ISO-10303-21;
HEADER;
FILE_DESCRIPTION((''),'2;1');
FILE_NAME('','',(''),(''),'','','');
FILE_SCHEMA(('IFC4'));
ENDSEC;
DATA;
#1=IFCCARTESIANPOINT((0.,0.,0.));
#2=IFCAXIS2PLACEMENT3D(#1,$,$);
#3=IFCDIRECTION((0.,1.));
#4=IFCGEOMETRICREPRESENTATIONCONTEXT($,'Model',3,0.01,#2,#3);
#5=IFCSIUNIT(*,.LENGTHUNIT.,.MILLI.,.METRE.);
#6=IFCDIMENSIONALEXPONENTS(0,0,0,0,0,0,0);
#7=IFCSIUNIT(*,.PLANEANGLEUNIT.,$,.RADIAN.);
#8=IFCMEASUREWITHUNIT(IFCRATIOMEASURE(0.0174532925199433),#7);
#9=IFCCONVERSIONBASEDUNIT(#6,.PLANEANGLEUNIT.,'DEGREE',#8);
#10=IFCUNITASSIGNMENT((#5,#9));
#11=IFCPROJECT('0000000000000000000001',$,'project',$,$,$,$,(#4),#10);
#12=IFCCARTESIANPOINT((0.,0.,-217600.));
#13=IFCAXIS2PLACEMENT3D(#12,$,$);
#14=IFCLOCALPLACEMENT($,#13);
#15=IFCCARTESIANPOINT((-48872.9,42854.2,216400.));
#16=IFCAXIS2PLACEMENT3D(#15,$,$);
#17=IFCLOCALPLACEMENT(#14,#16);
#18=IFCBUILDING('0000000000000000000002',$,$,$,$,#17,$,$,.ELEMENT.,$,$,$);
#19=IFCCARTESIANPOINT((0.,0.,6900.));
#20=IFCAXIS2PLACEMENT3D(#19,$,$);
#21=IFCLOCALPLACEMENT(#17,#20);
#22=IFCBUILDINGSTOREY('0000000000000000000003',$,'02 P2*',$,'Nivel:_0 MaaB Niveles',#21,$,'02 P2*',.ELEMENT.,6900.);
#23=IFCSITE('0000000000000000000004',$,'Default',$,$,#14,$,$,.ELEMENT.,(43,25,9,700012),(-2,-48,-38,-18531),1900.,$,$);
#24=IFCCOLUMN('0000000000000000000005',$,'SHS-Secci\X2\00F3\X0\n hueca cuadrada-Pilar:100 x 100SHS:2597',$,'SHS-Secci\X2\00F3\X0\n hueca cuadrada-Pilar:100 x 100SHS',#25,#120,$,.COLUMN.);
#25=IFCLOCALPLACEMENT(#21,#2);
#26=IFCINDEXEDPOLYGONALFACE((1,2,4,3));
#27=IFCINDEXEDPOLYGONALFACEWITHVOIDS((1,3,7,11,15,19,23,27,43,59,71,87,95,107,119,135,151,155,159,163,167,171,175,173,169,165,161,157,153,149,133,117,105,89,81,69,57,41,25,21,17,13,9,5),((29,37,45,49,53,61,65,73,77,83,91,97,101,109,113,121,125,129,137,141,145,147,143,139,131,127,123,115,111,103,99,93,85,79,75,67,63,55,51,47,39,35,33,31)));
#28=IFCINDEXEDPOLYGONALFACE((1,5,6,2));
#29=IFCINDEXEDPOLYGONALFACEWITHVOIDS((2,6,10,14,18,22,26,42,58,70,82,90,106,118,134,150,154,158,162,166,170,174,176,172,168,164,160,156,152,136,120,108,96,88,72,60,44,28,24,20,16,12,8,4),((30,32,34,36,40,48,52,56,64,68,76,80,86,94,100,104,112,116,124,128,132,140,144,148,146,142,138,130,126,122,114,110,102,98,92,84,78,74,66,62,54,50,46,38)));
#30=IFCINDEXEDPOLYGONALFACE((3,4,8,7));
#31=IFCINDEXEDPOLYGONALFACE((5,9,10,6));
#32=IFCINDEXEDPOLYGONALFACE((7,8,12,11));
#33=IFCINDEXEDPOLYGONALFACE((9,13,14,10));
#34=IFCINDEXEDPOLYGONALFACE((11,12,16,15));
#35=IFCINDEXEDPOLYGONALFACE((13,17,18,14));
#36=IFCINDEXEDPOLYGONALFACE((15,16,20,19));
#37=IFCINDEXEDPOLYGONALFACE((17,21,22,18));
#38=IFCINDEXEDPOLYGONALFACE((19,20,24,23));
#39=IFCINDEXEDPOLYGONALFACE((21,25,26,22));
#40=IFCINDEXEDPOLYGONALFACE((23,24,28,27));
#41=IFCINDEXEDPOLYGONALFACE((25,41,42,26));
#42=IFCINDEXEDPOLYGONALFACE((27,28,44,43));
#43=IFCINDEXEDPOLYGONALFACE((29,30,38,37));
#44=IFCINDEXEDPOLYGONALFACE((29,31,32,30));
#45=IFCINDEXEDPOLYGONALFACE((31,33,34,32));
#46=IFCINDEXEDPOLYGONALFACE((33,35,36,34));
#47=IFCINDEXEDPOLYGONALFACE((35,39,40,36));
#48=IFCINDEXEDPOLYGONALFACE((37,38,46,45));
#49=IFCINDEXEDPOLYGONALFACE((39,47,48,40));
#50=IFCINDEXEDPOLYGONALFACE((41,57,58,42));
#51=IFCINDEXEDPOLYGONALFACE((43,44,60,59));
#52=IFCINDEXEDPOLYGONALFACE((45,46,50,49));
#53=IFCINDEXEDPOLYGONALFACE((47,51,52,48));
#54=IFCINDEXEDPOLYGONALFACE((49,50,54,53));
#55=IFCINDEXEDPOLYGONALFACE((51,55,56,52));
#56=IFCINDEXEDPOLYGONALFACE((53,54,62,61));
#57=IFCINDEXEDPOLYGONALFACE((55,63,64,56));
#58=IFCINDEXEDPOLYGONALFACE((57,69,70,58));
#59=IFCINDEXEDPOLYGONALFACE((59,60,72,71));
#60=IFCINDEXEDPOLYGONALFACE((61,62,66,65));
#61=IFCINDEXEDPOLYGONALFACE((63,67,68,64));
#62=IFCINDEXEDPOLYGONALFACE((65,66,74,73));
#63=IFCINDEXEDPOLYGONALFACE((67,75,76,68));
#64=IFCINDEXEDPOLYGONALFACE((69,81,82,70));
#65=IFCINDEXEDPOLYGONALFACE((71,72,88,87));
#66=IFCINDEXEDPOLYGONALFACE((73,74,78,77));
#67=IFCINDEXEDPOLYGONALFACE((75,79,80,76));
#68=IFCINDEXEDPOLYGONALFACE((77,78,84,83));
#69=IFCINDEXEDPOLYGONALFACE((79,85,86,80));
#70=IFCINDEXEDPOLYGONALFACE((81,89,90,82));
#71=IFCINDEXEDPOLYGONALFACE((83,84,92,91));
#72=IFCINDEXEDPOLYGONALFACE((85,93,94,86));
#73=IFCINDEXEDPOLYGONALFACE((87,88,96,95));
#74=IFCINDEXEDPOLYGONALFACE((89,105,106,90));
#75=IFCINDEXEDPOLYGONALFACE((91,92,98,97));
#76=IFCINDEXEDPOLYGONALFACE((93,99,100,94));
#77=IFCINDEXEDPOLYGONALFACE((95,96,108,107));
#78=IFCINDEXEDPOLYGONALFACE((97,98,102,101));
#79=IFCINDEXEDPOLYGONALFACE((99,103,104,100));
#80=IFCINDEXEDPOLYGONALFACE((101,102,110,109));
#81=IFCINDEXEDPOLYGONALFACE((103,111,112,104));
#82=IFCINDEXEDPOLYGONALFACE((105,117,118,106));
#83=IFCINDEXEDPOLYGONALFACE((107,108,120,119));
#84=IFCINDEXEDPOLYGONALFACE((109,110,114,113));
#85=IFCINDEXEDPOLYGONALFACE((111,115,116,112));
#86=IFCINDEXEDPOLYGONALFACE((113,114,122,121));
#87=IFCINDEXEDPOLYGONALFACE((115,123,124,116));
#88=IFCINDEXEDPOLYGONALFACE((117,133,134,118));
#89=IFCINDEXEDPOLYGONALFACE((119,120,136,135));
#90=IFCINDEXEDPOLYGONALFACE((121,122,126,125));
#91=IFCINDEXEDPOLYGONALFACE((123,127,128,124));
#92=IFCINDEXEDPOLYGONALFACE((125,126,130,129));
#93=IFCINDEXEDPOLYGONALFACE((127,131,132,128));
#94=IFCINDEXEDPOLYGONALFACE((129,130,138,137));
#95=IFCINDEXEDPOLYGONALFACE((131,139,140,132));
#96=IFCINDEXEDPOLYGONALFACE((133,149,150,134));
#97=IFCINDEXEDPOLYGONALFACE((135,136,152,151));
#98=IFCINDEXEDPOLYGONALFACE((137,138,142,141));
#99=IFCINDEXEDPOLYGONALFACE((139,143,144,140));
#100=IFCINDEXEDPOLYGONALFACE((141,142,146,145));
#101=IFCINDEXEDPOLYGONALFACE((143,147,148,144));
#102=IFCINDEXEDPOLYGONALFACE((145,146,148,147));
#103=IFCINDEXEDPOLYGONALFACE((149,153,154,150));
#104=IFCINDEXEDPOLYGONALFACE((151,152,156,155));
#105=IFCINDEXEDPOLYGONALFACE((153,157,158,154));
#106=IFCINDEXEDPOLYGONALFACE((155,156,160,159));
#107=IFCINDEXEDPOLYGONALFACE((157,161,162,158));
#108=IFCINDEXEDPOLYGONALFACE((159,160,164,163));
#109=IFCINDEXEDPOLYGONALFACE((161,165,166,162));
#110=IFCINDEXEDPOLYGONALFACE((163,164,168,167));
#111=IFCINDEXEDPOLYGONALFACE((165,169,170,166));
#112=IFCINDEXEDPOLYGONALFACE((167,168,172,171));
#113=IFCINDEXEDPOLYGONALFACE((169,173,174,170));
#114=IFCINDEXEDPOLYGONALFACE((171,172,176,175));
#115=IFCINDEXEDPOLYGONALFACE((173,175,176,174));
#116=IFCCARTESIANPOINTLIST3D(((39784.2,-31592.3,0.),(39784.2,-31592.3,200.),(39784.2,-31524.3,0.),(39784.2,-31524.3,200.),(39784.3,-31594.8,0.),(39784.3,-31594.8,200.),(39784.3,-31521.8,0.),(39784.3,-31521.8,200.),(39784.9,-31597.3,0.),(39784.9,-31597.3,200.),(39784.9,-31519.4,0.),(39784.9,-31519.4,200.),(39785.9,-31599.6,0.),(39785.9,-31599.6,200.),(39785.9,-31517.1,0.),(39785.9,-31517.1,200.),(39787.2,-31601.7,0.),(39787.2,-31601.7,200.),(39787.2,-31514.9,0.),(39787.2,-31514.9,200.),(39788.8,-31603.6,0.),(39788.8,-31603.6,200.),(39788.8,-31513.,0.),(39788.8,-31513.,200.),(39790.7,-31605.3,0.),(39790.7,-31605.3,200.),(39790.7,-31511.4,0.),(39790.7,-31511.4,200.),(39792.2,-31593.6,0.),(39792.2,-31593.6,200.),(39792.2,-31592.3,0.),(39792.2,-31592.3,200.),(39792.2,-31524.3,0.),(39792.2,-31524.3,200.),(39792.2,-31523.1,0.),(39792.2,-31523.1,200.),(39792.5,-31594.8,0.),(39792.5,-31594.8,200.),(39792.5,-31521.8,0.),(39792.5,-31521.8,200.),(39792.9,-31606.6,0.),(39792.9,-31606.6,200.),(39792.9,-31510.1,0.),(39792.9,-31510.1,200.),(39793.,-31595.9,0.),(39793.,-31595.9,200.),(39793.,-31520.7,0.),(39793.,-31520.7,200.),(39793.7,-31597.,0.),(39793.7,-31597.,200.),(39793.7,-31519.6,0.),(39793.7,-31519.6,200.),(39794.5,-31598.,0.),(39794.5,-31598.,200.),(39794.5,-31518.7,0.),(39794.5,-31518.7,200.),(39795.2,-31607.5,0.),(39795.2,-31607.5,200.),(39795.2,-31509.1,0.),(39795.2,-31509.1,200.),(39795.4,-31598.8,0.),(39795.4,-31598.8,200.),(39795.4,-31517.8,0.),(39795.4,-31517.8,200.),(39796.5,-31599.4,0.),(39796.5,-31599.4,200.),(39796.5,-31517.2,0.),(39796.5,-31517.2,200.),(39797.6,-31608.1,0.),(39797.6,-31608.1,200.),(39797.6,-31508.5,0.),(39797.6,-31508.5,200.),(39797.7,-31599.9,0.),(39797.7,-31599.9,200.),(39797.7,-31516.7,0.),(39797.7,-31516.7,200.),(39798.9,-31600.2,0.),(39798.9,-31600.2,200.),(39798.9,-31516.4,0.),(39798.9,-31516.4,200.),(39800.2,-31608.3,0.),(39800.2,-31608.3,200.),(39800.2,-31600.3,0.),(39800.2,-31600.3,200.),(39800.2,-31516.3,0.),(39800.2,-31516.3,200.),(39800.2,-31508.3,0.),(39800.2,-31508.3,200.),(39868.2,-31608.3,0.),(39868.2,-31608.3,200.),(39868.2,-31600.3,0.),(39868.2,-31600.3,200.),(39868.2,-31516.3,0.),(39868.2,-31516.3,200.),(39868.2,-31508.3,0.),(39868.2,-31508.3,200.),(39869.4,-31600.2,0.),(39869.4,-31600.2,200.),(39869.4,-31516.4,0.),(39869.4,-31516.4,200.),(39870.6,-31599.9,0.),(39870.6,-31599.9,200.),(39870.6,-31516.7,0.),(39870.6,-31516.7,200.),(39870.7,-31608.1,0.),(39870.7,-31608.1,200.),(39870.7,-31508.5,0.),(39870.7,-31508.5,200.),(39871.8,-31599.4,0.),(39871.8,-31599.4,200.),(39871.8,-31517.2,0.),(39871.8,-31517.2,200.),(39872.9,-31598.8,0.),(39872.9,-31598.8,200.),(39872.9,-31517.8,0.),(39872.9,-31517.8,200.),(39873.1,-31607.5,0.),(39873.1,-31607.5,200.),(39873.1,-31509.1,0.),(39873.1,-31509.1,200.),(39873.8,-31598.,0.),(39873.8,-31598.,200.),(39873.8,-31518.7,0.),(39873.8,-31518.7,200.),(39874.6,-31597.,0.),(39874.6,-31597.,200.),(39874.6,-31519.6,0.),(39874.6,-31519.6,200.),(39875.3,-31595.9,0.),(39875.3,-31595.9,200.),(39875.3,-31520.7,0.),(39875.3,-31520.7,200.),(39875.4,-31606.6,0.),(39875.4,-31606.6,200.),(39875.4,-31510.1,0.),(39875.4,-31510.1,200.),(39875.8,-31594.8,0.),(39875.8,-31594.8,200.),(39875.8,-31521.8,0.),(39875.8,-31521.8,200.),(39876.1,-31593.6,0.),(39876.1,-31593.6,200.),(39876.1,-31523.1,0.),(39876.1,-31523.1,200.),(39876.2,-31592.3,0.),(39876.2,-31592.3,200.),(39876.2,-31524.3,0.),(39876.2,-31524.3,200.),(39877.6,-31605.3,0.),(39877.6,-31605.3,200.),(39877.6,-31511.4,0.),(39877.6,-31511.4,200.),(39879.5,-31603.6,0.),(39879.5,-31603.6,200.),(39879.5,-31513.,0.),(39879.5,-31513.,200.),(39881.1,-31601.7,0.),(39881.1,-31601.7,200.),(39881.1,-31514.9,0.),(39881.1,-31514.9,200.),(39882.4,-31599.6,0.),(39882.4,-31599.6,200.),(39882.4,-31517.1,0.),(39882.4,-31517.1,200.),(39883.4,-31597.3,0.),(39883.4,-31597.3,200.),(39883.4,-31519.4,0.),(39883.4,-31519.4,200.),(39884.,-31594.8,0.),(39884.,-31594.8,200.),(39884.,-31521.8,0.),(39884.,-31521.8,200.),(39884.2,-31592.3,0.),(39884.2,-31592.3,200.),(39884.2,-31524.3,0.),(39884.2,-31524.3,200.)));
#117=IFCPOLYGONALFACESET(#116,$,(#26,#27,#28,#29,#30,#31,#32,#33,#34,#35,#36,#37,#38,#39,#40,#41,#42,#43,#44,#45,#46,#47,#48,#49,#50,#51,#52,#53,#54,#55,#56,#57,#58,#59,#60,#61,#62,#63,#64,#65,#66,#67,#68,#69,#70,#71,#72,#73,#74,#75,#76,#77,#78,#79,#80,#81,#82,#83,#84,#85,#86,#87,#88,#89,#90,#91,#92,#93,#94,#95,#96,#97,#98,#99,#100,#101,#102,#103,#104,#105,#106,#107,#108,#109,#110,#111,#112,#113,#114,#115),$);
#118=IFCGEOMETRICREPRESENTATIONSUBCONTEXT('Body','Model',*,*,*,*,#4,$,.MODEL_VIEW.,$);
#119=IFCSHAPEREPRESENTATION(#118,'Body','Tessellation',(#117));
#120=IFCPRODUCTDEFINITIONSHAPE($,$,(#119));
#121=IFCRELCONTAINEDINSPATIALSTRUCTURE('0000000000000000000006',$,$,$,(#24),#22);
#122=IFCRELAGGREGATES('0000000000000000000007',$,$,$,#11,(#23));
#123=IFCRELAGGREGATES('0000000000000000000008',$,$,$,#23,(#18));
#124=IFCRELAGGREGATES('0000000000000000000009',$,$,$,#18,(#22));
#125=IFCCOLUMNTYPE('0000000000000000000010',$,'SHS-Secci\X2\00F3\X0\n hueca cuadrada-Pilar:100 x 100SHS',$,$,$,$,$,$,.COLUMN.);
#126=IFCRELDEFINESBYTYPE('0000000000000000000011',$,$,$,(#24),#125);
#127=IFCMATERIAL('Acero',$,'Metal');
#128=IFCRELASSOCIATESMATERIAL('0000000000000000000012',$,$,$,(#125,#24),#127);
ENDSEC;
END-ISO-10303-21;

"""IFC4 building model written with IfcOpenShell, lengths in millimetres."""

from ifc_helpers import new_model, entity, si_unit, converted_unit, direction, frame, origin, place, context, subcontext, project, spatial, indexed_curve, outline, extrude, source, transform, mapped, material, type_object, type_shapes, element, save


model = new_model("IFC4")

# Units and contexts
model_context = context("Model", 3, precision=0.01, world=origin(), true_north=direction((0.0, 1.0)))
body_context = subcontext(model_context, "Body", "Model", "MODEL_VIEW")
ifc_project = project(units=[si_unit("LENGTHUNIT", "METRE", prefix="MILLI"), converted_unit("PLANEANGLEUNIT", "DEGREE", entity("IfcRatioMeasure", 0.0174532925199433), si_unit("PLANEANGLEUNIT", "RADIAN"), dimensions=[0, 0, 0, 0, 0, 0, 0])], contexts=[model_context])

# Site, building, storey
site_placement = place(None, frame((0.0, 0.0, -217600.0)))
site = spatial("IfcSite", under=ifc_project, at=site_placement, Name="Default", CompositionType="ELEMENT", RefLatitude=(43, 25, 9, 700012), RefLongitude=(-2, -48, -38, -18531), RefElevation=1900.0)
building_placement = place(site_placement, frame((-48872.9, 42854.2, 216400.0)))
building = spatial("IfcBuilding", under=site, at=building_placement, CompositionType="ELEMENT")
storey_placement = place(building_placement, frame((0.0, 0.0, 6900.0)))
storey = spatial("IfcBuildingStorey", under=building, at=storey_placement, Name="02 P2*", ObjectType="Nivel:_0 MaaB Niveles", LongName="02 P2*", CompositionType="ELEMENT", Elevation=6900.0)

# Column
ifc_material_1 = material(Name="Acero", Category="Metal")
column_type_1 = type_object("IfcColumnType", Name="SHS-Sección hueca cuadrada-Pilar:100 x 100SHS", PredefinedType="COLUMN", material=ifc_material_1)
shared_shape_1 = source(origin(), body_context, "Body", "SweptSolid", [
    extrude(outline(indexed_curve([(-34.0, -50.0), (34.0, -50.0), (36.5, -49.8), (38.9, -49.2), (41.3, -48.3), (43.4, -46.9), (45.3, -45.3), (46.9, -43.4), (48.3, -41.3), (49.2, -38.9), (49.8, -36.5), (50.0, -34.0), (50.0, 34.0), (49.8, 36.5), (49.2, 38.9), (48.3, 41.3), (46.9, 43.4), (45.3, 45.3), (43.4, 46.9), (41.3, 48.3), (38.9, 49.2), (36.5, 49.8), (34.0, 50.0), (-34.0, 50.0), (-36.5, 49.8), (-38.9, 49.2), (-41.3, 48.3), (-43.4, 46.9), (-45.3, 45.3), (-46.9, 43.4), (-48.3, 41.3), (-49.2, 38.9), (-49.8, 36.5), (-50.0, 34.0), (-50.0, -34.0), (-49.8, -36.5), (-49.2, -38.9), (-48.3, -41.3), (-46.9, -43.4), (-45.3, -45.3), (-43.4, -46.9), (-41.3, -48.3), (-38.9, -49.2), (-36.5, -49.8), (-34.0, -50.0)], self_intersect=False), holes=[indexed_curve([(-34.0, -42.0), (-35.3, -41.9), (-36.5, -41.6), (-37.6, -41.1), (-38.7, -40.5), (-39.7, -39.7), (-40.5, -38.7), (-41.1, -37.6), (-41.6, -36.5), (-41.9, -35.3), (-42.0, -34.0), (-42.0, 34.0), (-41.9, 35.3), (-41.6, 36.5), (-41.1, 37.6), (-40.5, 38.7), (-39.7, 39.7), (-38.7, 40.5), (-37.6, 41.1), (-36.5, 41.6), (-35.3, 41.9), (-34.0, 42.0), (34.0, 42.0), (35.3, 41.9), (36.5, 41.6), (37.6, 41.1), (38.7, 40.5), (39.7, 39.7), (40.5, 38.7), (41.1, 37.6), (41.6, 36.5), (41.9, 35.3), (42.0, 34.0), (42.0, -34.0), (41.9, -35.3), (41.6, -36.5), (41.1, -37.6), (40.5, -38.7), (39.7, -39.7), (38.7, -40.5), (37.6, -41.1), (36.5, -41.6), (35.3, -41.9), (34.0, -42.0), (-34.0, -42.0)], self_intersect=False)]), frame((0.0, 0.0, 6900.0), z_axis=(0.0, 0.0, 1.0), x_axis=(-1.0, 0.0, 0.0)), (0.0, 0.0, 1.0), 200.0),
])
type_shapes(column_type_1, [shared_shape_1])
column_1_placement = place(storey_placement, frame((39834.2, -31558.3, -6900.0), z_axis=(0.0, 0.0, 1.0), x_axis=(0.0, -1.0, 0.0)))
element("IfcColumn", 1, at=column_1_placement, inside=storey, type_object=column_type_1, material=ifc_material_1, Name="SHS-Sección hueca cuadrada-Pilar:100 x 100SHS:2597", ObjectType="SHS-Sección hueca cuadrada-Pilar:100 x 100SHS", PredefinedType="COLUMN", context=body_context, shape_type="MappedRepresentation", body=[
    mapped(shared_shape_1, transform((0.0, 0.0, 0.0), scale=1.0)),
])

save(model, "model.ifc")
